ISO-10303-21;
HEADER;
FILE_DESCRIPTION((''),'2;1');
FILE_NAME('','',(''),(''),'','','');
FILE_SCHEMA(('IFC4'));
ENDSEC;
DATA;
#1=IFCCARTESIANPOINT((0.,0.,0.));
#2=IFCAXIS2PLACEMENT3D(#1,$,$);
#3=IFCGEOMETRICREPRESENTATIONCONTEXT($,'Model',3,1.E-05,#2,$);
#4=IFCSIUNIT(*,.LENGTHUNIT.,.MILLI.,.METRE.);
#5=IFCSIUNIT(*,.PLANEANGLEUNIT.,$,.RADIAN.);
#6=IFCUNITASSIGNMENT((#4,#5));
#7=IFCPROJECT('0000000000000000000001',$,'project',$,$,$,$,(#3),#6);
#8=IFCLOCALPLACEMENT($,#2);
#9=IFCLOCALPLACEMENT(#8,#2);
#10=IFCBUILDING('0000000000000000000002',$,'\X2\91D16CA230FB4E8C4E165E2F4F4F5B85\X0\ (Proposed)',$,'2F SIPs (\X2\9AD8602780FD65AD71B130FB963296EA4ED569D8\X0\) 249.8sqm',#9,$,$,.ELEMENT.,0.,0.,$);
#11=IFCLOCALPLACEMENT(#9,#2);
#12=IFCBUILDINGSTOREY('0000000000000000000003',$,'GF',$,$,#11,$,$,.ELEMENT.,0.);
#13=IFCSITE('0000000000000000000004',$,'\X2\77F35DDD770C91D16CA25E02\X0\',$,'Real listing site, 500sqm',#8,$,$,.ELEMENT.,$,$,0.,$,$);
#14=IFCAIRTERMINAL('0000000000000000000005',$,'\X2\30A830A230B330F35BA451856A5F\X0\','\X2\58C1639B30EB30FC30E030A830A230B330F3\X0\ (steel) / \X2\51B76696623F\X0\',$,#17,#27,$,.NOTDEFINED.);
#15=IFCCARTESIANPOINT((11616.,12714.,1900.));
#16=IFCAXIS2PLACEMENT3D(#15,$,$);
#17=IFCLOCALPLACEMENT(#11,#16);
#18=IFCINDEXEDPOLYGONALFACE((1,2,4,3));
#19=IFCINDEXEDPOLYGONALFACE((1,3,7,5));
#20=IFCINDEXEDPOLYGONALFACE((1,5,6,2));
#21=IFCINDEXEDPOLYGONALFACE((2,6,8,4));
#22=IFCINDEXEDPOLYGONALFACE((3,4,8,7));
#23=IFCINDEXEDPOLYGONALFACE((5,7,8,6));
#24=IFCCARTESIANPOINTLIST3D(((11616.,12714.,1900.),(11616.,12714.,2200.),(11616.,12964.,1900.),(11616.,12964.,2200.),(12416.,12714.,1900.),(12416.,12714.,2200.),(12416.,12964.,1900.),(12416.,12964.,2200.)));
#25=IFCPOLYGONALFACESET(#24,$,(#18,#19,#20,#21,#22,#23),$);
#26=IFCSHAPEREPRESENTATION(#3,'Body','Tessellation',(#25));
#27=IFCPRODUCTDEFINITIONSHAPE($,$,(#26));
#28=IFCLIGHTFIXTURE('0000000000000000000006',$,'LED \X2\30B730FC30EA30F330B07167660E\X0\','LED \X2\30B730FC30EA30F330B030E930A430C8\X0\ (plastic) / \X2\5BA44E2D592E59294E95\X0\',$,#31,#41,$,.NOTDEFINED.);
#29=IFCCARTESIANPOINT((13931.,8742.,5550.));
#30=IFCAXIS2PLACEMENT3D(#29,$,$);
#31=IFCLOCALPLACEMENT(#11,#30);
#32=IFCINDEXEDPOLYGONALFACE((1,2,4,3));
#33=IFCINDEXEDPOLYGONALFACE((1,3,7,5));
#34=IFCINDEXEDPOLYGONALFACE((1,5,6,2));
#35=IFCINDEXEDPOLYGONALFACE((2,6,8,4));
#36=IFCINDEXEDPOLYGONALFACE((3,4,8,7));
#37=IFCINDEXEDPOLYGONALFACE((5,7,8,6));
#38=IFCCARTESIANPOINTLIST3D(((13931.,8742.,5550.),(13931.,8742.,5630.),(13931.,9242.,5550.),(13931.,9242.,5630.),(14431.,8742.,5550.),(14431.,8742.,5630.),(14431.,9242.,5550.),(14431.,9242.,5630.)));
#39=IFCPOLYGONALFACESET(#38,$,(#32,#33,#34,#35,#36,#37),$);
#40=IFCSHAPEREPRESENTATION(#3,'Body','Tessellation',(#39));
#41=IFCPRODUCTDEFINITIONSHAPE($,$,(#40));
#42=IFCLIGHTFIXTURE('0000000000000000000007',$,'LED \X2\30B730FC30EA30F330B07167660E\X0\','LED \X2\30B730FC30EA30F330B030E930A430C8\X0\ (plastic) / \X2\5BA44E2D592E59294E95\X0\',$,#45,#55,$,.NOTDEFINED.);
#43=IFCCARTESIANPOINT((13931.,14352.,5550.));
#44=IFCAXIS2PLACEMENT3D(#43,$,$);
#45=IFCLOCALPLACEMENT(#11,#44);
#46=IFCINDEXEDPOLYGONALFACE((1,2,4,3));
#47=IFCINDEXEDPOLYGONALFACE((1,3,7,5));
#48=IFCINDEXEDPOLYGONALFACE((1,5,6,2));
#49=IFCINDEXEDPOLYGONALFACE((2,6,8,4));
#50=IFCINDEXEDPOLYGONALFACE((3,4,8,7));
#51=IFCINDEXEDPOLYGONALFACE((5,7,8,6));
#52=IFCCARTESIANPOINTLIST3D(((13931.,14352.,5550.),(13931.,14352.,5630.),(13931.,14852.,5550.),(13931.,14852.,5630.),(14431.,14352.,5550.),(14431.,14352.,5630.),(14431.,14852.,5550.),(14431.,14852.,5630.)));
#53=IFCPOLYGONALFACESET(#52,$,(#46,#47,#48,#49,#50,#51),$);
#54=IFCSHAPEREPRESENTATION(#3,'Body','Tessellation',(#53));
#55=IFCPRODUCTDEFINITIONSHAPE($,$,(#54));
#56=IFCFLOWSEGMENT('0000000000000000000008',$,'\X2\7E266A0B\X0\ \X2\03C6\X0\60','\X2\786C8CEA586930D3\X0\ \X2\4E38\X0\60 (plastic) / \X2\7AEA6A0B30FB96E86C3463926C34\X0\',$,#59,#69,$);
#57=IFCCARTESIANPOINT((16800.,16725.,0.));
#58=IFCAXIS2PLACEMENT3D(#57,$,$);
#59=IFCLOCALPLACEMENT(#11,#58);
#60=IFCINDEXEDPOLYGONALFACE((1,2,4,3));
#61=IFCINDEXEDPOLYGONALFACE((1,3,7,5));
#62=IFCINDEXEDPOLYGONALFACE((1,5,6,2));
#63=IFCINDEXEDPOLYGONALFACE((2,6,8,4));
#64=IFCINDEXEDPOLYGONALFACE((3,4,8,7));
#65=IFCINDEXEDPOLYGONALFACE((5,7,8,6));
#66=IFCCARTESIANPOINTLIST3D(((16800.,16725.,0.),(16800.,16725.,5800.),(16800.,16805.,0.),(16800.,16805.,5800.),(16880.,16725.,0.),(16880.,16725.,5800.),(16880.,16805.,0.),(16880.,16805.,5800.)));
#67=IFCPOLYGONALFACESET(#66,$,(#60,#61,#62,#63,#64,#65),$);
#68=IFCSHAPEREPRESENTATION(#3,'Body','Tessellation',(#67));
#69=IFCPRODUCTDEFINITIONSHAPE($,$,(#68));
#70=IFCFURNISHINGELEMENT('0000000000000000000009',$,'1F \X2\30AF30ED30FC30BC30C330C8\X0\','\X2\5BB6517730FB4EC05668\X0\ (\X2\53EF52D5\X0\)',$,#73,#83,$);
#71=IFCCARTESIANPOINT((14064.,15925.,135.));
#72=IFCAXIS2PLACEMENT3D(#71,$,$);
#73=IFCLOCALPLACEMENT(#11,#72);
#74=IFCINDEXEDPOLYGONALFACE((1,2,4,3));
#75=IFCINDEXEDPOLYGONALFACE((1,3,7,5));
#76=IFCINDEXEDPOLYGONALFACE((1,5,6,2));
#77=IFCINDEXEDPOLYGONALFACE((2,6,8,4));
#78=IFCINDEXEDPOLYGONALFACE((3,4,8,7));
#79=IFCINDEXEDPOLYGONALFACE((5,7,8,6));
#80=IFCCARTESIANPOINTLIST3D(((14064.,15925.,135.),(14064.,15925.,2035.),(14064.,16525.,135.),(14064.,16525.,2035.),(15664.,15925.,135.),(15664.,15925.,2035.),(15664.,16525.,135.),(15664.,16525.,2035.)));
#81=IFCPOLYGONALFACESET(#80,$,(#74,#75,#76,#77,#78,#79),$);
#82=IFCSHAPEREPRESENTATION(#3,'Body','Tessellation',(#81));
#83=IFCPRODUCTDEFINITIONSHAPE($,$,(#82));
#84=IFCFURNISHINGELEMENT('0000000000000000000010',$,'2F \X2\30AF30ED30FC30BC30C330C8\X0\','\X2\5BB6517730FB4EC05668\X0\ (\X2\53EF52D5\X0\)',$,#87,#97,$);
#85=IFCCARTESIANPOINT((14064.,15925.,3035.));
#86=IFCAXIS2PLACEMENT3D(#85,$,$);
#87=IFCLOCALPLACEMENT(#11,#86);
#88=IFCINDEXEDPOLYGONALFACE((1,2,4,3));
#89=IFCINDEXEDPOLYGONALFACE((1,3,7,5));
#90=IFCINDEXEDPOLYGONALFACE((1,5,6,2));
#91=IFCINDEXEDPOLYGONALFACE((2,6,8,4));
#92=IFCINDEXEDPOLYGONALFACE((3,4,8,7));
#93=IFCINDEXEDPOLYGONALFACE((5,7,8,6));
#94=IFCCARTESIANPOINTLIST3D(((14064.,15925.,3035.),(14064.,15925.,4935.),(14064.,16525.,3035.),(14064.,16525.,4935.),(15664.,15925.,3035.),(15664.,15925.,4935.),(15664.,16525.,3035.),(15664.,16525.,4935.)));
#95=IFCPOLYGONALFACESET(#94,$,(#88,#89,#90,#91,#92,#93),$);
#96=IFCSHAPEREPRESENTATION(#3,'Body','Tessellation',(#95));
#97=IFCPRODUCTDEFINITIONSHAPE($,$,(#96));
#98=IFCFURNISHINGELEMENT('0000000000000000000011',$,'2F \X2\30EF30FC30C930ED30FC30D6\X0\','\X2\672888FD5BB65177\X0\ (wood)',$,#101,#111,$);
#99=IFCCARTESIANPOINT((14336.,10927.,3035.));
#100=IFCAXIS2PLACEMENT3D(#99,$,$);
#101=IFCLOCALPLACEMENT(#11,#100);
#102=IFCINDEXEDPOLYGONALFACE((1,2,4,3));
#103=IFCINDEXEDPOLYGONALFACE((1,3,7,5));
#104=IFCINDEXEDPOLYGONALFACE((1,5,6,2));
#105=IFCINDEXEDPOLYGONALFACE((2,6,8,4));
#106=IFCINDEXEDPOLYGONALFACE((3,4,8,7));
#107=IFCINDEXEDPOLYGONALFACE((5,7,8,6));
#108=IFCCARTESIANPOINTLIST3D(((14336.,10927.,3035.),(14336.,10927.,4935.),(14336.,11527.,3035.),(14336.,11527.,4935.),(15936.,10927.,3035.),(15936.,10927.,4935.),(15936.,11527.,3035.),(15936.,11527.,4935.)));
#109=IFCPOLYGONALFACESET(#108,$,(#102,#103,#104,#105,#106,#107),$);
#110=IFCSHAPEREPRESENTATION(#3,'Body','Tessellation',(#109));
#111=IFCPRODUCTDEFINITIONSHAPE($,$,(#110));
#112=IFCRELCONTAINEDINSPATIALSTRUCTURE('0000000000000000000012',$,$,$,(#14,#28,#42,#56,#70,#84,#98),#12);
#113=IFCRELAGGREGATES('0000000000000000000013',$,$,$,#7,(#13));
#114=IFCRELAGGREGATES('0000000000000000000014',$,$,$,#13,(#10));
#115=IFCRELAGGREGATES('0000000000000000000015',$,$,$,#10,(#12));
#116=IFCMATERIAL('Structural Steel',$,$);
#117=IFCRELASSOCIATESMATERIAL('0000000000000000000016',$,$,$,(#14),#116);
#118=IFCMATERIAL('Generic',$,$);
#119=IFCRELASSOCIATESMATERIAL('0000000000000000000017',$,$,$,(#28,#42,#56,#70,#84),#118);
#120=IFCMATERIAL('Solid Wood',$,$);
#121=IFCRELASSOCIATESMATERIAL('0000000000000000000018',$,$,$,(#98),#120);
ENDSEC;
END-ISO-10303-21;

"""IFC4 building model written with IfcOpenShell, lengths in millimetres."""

from ifc_helpers import new_model, si_unit, frame, frame_2d, origin, place, context, project, spatial, rectangle, extrude, material, element, save


model = new_model("IFC4")

# Units and contexts
model_context = context("Model", 3, precision=1e-05, world=origin())
ifc_project = project(units=[si_unit("LENGTHUNIT", "METRE", prefix="MILLI"), si_unit("PLANEANGLEUNIT", "RADIAN")], contexts=[model_context])

# Site, building, storey
site_placement = place(None, origin())
site = spatial("IfcSite", under=ifc_project, at=site_placement, Name="石川県金沢市", ObjectType="Real listing site, 500sqm", CompositionType="ELEMENT", RefElevation=0.0)
building_placement = place(site_placement, origin())
building = spatial("IfcBuilding", under=site, at=building_placement, Name="金沢・二世帯住宅 (Proposed)", ObjectType="2F SIPs (高性能断熱・防雪仕様) 249.8sqm", CompositionType="ELEMENT", ElevationOfRefHeight=0.0, ElevationOfTerrain=0.0)
storey_placement = place(building_placement, origin())
storey = spatial("IfcBuildingStorey", under=building, at=storey_placement, Name="GF", CompositionType="ELEMENT", Elevation=0.0)

# Shared definitions
ifc_material_1 = material(Name="Solid Wood")

# Shared definitions
ifc_material_2 = material(Name="Structural Steel")

# Shared definitions
ifc_material_3 = material(Name="Generic")

# Air terminal
air_terminal_placement = place(storey_placement, frame((11616.0, 12714.0, 1900.0)))
element("IfcAirTerminal", 1, at=air_terminal_placement, inside=storey, material=ifc_material_2, Name="エアコン室内機", Description="壁掛ルームエアコン (steel) / 冷暖房", PredefinedType="NOTDEFINED", context=model_context, shape_type="SweptSolid", body=[
    extrude(rectangle(XDim=800.0, YDim=250.0, at=frame_2d((400.0, 125.0))), frame((11616.0, 12714.0, 1900.0)), (0.0, 0.0, 1.0), 300.0),
])

# Light fixtures
light_fixture_1_placement = place(storey_placement, frame((13931.0, 8742.0, 5550.0)))
element("IfcLightFixture", 2, at=light_fixture_1_placement, inside=storey, material=ifc_material_3, Name="LED シーリング照明", Description="LED シーリングライト (plastic) / 室中央天井", PredefinedType="NOTDEFINED", context=model_context, shape_type="SweptSolid", body=[
    extrude(rectangle(XDim=500.0, YDim=500.0, at=frame_2d((250.0, 250.0))), frame((13931.0, 8742.0, 5550.0)), (0.0, 0.0, 1.0), 80.0),
])
light_fixture_2_placement = place(storey_placement, frame((13931.0, 14352.0, 5550.0)))
element("IfcLightFixture", 3, at=light_fixture_2_placement, inside=storey, material=ifc_material_3, Name="LED シーリング照明", Description="LED シーリングライト (plastic) / 室中央天井", PredefinedType="NOTDEFINED", context=model_context, shape_type="SweptSolid", body=[
    extrude(rectangle(XDim=500.0, YDim=500.0, at=frame_2d((250.0, 250.0))), frame((13931.0, 14352.0, 5550.0)), (0.0, 0.0, 1.0), 80.0),
])

# Flow segment
flow_segment_placement = place(storey_placement, frame((16800.0, 16725.0, 0.0)))
element("IfcFlowSegment", 4, at=flow_segment_placement, inside=storey, material=ifc_material_3, Name="縦樋 φ60", Description="硬質塩ビ 丸60 (plastic) / 竪樋・雨水排水", context=model_context, shape_type="SweptSolid", body=[
    extrude(rectangle(XDim=80.0, YDim=80.0, at=frame_2d((40.0, 40.0))), frame((16800.0, 16725.0, 0.0)), (0.0, 0.0, 1.0), 5800.0),
])

# Furnishing elements
furnishing_1_placement = place(storey_placement, frame((14064.0, 15925.0, 135.0)))
element("IfcFurnishingElement", 5, at=furnishing_1_placement, inside=storey, material=ifc_material_3, Name="1F クローゼット", Description="家具・什器 (可動)", context=model_context, shape_type="SweptSolid", body=[
    extrude(rectangle(XDim=1600.0, YDim=600.0, at=frame_2d((800.0, 300.0))), frame((14064.0, 15925.0, 135.0)), (0.0, 0.0, 1.0), 1900.0),
])
furnishing_2_placement = place(storey_placement, frame((14064.0, 15925.0, 3035.0)))
element("IfcFurnishingElement", 6, at=furnishing_2_placement, inside=storey, material=ifc_material_3, Name="2F クローゼット", Description="家具・什器 (可動)", context=model_context, shape_type="SweptSolid", body=[
    extrude(rectangle(XDim=1600.0, YDim=600.0, at=frame_2d((800.0, 300.0))), frame((14064.0, 15925.0, 3035.0)), (0.0, 0.0, 1.0), 1900.0),
])
furnishing_3_placement = place(storey_placement, frame((14336.0, 10927.0, 3035.0)))
element("IfcFurnishingElement", 7, at=furnishing_3_placement, inside=storey, material=ifc_material_1, Name="2F ワードローブ", Description="木製家具 (wood)", context=model_context, shape_type="SweptSolid", body=[
    extrude(rectangle(XDim=1600.0, YDim=600.0, at=frame_2d((800.0, 300.0))), frame((14336.0, 10927.0, 3035.0)), (0.0, 0.0, 1.0), 1900.0),
])

save(model, "model.ifc")
